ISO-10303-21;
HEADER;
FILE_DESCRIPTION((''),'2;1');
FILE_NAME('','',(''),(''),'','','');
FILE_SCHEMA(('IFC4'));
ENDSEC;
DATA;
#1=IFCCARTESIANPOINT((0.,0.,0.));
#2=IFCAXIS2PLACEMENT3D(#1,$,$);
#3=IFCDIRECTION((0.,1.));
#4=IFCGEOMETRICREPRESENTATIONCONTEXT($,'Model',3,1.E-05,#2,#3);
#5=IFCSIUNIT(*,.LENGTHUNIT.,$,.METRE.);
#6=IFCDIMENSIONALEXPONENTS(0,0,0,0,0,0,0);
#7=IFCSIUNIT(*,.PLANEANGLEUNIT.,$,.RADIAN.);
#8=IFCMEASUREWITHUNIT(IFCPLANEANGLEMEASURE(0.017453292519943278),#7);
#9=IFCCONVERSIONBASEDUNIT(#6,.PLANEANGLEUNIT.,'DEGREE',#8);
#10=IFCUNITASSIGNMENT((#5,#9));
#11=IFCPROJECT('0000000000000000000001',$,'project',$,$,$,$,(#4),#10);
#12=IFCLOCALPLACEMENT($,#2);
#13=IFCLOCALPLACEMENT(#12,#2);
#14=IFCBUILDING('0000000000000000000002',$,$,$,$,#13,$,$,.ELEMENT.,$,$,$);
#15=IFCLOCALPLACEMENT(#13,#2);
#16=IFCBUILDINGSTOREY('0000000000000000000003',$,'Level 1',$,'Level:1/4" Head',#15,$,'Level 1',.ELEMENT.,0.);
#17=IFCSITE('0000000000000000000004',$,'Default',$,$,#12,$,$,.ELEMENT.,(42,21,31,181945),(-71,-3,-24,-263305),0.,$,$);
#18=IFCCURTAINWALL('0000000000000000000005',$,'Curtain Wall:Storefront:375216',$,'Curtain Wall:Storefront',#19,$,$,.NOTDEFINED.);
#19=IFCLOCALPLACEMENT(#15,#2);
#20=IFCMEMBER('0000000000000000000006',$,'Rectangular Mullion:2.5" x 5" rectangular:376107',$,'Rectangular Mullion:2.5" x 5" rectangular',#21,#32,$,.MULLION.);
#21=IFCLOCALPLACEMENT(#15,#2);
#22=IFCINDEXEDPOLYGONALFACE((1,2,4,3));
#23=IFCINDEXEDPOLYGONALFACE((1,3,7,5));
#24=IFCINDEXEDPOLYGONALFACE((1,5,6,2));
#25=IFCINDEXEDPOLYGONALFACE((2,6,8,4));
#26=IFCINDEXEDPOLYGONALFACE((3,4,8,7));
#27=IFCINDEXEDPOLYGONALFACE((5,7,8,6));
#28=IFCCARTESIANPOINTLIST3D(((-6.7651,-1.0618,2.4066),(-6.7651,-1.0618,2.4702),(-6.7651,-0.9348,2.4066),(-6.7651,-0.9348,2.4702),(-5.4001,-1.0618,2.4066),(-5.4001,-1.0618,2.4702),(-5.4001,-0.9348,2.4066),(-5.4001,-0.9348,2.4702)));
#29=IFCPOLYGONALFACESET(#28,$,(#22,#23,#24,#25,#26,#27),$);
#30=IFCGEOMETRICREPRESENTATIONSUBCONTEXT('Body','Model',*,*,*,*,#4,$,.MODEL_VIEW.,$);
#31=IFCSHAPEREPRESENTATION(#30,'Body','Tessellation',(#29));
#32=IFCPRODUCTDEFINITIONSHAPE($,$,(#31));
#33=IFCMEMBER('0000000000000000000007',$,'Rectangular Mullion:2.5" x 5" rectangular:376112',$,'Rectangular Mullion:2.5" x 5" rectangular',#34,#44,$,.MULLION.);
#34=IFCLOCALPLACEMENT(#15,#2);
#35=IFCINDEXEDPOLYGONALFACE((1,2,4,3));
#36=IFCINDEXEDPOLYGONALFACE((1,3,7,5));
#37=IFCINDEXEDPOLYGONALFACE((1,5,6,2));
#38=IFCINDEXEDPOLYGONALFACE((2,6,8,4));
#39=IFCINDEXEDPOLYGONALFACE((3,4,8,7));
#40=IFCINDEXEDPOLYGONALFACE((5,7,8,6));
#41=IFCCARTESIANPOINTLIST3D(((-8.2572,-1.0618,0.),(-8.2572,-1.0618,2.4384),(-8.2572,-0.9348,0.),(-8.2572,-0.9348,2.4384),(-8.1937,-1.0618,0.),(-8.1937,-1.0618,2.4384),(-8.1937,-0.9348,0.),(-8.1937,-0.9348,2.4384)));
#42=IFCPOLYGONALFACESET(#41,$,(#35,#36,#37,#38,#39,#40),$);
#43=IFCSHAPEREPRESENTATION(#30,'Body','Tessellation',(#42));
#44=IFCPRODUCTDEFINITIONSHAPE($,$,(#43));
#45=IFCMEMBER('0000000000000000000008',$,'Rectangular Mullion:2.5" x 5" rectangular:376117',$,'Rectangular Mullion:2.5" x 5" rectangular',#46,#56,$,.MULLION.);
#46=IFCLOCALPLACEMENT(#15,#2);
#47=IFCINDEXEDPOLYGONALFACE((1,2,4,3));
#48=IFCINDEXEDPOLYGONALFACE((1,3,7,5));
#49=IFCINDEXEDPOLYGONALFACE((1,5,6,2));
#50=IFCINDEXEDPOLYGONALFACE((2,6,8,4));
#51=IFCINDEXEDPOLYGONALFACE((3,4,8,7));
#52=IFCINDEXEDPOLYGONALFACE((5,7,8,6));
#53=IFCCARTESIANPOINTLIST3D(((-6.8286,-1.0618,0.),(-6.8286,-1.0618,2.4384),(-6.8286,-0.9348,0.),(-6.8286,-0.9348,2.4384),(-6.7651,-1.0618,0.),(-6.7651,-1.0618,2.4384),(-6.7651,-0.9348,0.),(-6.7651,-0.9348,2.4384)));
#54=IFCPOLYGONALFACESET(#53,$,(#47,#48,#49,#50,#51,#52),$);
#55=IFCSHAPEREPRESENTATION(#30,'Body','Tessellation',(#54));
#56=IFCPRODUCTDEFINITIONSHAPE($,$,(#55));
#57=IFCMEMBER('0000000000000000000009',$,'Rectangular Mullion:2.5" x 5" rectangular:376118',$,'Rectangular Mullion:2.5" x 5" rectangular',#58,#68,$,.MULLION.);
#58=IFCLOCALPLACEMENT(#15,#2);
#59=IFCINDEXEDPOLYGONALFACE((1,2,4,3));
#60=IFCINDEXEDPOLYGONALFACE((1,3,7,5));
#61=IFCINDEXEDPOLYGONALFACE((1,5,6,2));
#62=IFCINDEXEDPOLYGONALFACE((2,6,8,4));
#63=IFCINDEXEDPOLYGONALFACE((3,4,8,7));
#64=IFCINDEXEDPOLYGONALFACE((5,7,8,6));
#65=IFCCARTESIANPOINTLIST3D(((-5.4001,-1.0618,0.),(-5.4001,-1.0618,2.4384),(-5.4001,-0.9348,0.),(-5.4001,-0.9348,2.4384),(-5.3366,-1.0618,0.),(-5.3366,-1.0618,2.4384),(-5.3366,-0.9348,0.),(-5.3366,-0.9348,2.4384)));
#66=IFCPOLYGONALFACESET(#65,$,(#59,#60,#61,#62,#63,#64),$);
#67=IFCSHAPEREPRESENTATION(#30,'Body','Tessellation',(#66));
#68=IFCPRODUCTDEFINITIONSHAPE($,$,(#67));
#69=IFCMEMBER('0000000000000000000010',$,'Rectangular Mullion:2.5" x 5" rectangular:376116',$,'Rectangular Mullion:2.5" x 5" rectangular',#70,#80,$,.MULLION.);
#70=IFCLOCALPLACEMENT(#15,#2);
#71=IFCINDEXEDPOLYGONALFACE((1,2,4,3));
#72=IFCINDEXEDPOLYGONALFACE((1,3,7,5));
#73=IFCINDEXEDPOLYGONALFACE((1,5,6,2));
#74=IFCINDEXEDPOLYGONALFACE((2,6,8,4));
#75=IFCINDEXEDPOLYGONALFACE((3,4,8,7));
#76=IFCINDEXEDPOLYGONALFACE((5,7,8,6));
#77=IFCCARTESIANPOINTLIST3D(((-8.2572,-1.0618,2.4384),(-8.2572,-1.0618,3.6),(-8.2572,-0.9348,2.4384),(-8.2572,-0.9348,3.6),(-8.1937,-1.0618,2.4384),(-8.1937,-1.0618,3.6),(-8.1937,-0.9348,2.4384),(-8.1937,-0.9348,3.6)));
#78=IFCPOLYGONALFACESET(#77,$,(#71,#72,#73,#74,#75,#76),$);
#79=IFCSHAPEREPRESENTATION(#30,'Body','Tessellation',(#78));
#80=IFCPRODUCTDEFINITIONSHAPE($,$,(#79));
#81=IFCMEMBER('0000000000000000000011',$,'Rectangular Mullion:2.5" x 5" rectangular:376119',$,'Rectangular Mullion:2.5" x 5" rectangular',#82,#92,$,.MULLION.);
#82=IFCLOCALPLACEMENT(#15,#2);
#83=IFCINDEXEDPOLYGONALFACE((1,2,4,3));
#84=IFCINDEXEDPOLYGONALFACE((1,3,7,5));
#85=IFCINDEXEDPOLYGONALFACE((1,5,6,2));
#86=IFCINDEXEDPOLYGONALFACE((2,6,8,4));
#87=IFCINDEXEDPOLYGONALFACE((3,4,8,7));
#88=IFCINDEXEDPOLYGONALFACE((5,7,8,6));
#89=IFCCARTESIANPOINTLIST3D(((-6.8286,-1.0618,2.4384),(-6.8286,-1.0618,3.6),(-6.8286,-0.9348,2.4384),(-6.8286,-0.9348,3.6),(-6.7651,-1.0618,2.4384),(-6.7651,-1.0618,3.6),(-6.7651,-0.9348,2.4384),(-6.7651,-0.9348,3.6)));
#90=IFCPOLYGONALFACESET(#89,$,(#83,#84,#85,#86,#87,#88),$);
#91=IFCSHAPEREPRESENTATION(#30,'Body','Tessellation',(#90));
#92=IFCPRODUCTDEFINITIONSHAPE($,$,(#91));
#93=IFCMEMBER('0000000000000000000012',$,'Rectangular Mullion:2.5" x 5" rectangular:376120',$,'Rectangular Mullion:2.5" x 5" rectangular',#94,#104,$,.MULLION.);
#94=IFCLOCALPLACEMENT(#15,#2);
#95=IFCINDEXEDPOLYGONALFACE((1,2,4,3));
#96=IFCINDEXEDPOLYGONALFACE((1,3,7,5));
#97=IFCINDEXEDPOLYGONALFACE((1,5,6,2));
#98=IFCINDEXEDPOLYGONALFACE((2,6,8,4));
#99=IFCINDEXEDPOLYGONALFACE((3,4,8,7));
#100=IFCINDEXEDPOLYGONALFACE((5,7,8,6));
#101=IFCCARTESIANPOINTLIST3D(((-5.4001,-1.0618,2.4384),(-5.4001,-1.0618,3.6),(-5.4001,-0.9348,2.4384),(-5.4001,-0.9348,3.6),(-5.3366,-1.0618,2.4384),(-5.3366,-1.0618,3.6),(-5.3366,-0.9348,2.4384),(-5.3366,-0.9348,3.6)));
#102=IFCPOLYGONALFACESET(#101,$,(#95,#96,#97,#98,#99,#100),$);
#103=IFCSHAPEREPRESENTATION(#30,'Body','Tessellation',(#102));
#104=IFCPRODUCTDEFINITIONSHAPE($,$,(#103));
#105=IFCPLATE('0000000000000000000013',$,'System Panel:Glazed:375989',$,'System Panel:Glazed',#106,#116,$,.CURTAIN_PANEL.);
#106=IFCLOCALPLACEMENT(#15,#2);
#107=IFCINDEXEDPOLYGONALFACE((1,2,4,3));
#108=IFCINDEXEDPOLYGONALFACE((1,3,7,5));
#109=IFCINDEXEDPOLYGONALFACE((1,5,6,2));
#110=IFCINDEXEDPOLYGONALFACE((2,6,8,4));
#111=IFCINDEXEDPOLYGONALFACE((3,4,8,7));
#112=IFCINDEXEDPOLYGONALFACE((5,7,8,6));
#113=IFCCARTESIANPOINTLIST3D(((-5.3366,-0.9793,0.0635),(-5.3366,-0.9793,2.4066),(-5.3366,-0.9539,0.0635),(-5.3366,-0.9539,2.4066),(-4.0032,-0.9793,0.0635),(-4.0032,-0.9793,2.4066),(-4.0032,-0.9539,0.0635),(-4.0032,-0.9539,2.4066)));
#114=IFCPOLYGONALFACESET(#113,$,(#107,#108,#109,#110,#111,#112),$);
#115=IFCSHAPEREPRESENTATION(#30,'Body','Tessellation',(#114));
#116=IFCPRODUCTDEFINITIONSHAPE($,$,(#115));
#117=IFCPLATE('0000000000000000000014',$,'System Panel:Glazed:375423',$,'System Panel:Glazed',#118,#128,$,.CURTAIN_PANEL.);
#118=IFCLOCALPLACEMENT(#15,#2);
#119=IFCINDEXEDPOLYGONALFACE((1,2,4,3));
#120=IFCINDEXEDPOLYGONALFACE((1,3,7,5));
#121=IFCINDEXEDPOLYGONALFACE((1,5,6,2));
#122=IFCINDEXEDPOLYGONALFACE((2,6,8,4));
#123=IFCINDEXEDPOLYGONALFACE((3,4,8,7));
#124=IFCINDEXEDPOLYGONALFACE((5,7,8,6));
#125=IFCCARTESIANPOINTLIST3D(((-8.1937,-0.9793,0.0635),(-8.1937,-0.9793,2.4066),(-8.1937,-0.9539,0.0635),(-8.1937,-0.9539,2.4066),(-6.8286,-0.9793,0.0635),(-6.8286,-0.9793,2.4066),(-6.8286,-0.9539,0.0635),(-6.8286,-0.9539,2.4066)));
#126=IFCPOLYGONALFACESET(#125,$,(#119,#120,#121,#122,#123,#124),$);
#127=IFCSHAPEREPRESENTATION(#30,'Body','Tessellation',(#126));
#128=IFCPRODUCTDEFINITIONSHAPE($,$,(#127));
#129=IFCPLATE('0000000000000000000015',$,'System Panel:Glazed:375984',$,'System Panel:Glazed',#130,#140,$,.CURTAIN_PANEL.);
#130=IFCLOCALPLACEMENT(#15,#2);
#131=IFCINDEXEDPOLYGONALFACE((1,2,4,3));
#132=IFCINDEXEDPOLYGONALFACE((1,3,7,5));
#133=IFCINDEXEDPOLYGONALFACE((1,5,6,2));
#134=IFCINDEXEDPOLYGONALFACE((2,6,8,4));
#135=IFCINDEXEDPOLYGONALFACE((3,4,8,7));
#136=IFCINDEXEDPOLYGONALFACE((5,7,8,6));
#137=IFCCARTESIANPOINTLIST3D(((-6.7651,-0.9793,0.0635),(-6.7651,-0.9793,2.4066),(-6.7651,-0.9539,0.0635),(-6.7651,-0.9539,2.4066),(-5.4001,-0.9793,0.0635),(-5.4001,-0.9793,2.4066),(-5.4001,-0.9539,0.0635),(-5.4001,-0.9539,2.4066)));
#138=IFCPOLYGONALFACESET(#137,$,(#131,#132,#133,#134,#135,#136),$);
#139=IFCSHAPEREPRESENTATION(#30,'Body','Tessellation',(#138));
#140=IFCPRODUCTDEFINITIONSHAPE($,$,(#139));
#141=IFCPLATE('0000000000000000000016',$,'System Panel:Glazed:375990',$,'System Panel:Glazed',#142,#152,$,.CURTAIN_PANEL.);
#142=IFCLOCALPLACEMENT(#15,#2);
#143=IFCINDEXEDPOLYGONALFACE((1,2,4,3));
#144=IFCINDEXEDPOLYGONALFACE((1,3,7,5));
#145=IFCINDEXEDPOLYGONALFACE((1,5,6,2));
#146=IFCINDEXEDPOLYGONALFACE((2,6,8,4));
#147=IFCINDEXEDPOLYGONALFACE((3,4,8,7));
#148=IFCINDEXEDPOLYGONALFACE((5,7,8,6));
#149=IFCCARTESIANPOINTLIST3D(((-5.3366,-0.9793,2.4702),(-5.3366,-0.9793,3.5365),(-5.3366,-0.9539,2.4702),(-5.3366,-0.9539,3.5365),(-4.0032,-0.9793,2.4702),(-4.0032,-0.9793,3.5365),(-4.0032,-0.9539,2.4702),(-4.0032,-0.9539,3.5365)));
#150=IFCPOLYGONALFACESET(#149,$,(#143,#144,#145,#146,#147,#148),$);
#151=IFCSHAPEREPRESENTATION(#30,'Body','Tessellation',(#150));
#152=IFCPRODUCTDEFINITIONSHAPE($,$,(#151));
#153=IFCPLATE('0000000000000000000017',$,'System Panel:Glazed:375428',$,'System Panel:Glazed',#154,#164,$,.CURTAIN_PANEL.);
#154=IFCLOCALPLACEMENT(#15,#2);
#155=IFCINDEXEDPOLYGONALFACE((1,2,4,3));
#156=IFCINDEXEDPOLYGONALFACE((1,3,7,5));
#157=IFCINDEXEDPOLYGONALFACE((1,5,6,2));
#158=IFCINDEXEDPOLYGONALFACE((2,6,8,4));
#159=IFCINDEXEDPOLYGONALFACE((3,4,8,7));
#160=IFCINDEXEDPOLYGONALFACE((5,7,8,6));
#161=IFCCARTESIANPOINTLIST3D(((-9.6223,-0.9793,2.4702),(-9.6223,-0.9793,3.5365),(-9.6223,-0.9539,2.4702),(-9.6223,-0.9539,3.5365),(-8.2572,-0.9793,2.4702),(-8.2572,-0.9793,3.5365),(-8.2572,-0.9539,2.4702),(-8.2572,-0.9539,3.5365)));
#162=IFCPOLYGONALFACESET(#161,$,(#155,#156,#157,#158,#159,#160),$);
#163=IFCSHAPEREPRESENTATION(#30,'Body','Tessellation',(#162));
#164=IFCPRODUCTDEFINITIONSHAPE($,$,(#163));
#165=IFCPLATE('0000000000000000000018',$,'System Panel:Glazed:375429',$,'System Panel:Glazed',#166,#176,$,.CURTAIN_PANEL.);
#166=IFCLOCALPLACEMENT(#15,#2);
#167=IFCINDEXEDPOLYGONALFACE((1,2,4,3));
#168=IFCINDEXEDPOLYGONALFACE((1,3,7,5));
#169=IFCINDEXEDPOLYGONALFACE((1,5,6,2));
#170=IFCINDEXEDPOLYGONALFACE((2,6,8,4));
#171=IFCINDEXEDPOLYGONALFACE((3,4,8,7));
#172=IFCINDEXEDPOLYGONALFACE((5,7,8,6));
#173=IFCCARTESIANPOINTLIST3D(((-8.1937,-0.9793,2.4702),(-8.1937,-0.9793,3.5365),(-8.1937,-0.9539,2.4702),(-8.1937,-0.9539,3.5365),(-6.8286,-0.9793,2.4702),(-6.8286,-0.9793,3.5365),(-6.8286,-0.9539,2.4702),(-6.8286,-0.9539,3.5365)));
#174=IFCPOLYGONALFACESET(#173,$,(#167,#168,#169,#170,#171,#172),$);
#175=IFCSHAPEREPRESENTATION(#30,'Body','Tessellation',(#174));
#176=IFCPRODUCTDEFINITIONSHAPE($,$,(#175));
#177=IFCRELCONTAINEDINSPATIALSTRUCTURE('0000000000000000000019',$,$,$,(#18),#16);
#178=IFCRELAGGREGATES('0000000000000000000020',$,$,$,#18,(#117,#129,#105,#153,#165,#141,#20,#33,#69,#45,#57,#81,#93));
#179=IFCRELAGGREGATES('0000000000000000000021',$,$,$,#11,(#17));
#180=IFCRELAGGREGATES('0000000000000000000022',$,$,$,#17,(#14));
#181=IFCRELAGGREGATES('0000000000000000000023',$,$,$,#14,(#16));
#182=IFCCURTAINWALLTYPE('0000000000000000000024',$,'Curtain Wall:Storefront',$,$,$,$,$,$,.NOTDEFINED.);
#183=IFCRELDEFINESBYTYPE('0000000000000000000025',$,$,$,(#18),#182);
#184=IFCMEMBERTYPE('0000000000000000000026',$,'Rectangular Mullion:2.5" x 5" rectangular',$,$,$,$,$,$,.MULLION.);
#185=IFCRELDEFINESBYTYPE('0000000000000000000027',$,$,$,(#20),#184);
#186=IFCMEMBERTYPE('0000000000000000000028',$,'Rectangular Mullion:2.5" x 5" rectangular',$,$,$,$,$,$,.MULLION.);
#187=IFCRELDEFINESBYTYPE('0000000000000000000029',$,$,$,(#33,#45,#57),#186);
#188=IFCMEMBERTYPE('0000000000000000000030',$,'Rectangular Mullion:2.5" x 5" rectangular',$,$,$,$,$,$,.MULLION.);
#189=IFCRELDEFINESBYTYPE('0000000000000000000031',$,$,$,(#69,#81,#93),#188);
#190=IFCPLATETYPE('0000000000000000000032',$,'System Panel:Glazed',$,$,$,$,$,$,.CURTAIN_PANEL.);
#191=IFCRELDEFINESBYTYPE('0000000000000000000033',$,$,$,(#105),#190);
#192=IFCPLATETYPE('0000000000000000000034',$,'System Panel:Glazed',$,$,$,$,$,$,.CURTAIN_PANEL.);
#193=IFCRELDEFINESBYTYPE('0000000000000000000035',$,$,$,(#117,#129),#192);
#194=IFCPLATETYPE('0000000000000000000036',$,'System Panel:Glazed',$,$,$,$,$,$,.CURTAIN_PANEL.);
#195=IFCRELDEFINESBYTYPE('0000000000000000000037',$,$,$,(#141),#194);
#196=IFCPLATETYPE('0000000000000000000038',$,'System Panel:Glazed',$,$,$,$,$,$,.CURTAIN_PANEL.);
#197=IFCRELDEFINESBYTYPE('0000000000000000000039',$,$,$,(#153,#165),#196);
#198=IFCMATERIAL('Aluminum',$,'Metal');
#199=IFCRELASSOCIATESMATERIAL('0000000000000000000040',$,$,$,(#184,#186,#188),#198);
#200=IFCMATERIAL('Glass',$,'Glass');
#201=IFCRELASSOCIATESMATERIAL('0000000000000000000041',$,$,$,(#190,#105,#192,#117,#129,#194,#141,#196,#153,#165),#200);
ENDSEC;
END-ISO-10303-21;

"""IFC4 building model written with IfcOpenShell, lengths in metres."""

from ifc_helpers import new_model, entity, si_unit, converted_unit, direction, frame, frame_2d, origin, origin_2d_with_axis, place, context, subcontext, project, spatial, rectangle, extrude, source, transform, mapped, material, material_profile, profile_set, type_object, type_shapes, element, aggregate, save


model = new_model("IFC4")

# Units and contexts
model_context = context("Model", 3, precision=1e-05, world=origin(), true_north=direction((0.0, 1.0)))
body_context = subcontext(model_context, "Body", "Model", "MODEL_VIEW")
ifc_project = project(units=[si_unit("LENGTHUNIT", "METRE"), converted_unit("PLANEANGLEUNIT", "DEGREE", entity("IfcPlaneAngleMeasure", 0.017453292519943278), si_unit("PLANEANGLEUNIT", "RADIAN"), dimensions=[0, 0, 0, 0, 0, 0, 0])], contexts=[model_context])

# Site, building, storey
site_placement = place(None, origin())
site = spatial("IfcSite", under=ifc_project, at=site_placement, Name="Default", CompositionType="ELEMENT", RefLatitude=(42, 21, 31, 181945), RefLongitude=(-71, -3, -24, -263305), RefElevation=0.0)
building_placement = place(site_placement, origin())
building = spatial("IfcBuilding", under=site, at=building_placement, CompositionType="ELEMENT")
storey_placement = place(building_placement, origin())
storey = spatial("IfcBuildingStorey", under=building, at=storey_placement, Name="Level 1", ObjectType="Level:1/4\" Head", LongName="Level 1", CompositionType="ELEMENT", Elevation=0.0)

# Curtain wall, members, plates
curtain_wall_type = type_object("IfcCurtainWallType", Name="Curtain Wall:Storefront", PredefinedType="NOTDEFINED")
curtain_wall_placement = place(storey_placement, origin())
curtain_wall = element("IfcCurtainWall", 1, at=curtain_wall_placement, inside=storey, type_object=curtain_wall_type, Name="Curtain Wall:Storefront:375216", ObjectType="Curtain Wall:Storefront", PredefinedType="NOTDEFINED")
ifc_material_1 = material(Name="Aluminum", Category="Metal")
ifc_material_profile = material_profile(ifc_material_1, rectangle(XDim=0.0635, YDim=0.127, at=frame_2d((0.0, 0.0), x_axis=(1.0, 0.0))), Name="2.5\" x 5\" rectangular")
ifc_profile_set = profile_set([ifc_material_profile], Name="2.5\" x 5\" rectangular")
member_type_1 = type_object("IfcMemberType", Name="Rectangular Mullion:2.5\" x 5\" rectangular", PredefinedType="MULLION", material=ifc_profile_set)
shared_shape_1 = source(origin(), body_context, "Body", "SweptSolid", [
    extrude(rectangle(XDim=0.0635, YDim=0.127, at=origin_2d_with_axis()), frame((0.0, 0.0, -1.3651), z_axis=(0.0, 0.0, 1.0), x_axis=(-1.0, 0.0, 0.0)), (0.0, 0.0, 1.0), 1.3651),
])
type_shapes(member_type_1, [shared_shape_1])
member_1_placement = place(curtain_wall_placement, frame((-5.4001, -0.9983, 2.4384), z_axis=(1.0, 0.0, 0.0), x_axis=(0.0, 0.0, 1.0)))
member_1 = element("IfcMember", 2, at=member_1_placement, type_object=member_type_1, Name="Rectangular Mullion:2.5\" x 5\" rectangular:376107", ObjectType="Rectangular Mullion:2.5\" x 5\" rectangular", PredefinedType="MULLION", context=body_context, shape_type="MappedRepresentation", body=[
    mapped(shared_shape_1, transform((0.0, 0.0, 0.0), scale=1.0)),
])
member_type_2 = type_object("IfcMemberType", Name="Rectangular Mullion:2.5\" x 5\" rectangular", PredefinedType="MULLION", material=ifc_profile_set)
shared_shape_2 = source(origin(), body_context, "Body", "SweptSolid", [
    extrude(rectangle(XDim=0.0635, YDim=0.127, at=origin_2d_with_axis()), frame((0.0, 0.0, -2.4384), z_axis=(0.0, 0.0, 1.0), x_axis=(-1.0, 0.0, 0.0)), (0.0, 0.0, 1.0), 2.4384),
])
type_shapes(member_type_2, [shared_shape_2])
member_2_placement = place(curtain_wall_placement, frame((-8.2254, -0.9983, 0.0), z_axis=(0.0, 0.0, -1.0), x_axis=(1.0, 0.0, 0.0)))
member_2 = element("IfcMember", 3, at=member_2_placement, type_object=member_type_2, Name="Rectangular Mullion:2.5\" x 5\" rectangular:376112", ObjectType="Rectangular Mullion:2.5\" x 5\" rectangular", PredefinedType="MULLION", context=body_context, shape_type="MappedRepresentation", body=[
    mapped(shared_shape_2, transform((0.0, 0.0, 0.0), scale=1.0)),
])
member_3_placement = place(curtain_wall_placement, frame((-6.7969, -0.9983, 0.0), z_axis=(0.0, 0.0, -1.0), x_axis=(1.0, 0.0, 0.0)))
member_3 = element("IfcMember", 4, at=member_3_placement, type_object=member_type_2, Name="Rectangular Mullion:2.5\" x 5\" rectangular:376117", ObjectType="Rectangular Mullion:2.5\" x 5\" rectangular", PredefinedType="MULLION", context=body_context, shape_type="MappedRepresentation", body=[
    mapped(shared_shape_2, transform((0.0, 0.0, 0.0), scale=1.0)),
])
member_4_placement = place(curtain_wall_placement, frame((-5.3683, -0.9983, 0.0), z_axis=(0.0, 0.0, -1.0), x_axis=(1.0, 0.0, 0.0)))
member_4 = element("IfcMember", 5, at=member_4_placement, type_object=member_type_2, Name="Rectangular Mullion:2.5\" x 5\" rectangular:376118", ObjectType="Rectangular Mullion:2.5\" x 5\" rectangular", PredefinedType="MULLION", context=body_context, shape_type="MappedRepresentation", body=[
    mapped(shared_shape_2, transform((0.0, 0.0, 0.0), scale=1.0)),
])
member_type_3 = type_object("IfcMemberType", Name="Rectangular Mullion:2.5\" x 5\" rectangular", PredefinedType="MULLION", material=ifc_profile_set)
shared_shape_3 = source(origin(), body_context, "Body", "SweptSolid", [
    extrude(rectangle(XDim=0.0635, YDim=0.127, at=origin_2d_with_axis()), frame((0.0, 0.0, -1.1616), z_axis=(0.0, 0.0, 1.0), x_axis=(-1.0, 0.0, 0.0)), (0.0, 0.0, 1.0), 1.1616),
])
type_shapes(member_type_3, [shared_shape_3])
member_5_placement = place(curtain_wall_placement, frame((-8.2254, -0.9983, 2.4384), z_axis=(0.0, 0.0, -1.0), x_axis=(1.0, 0.0, 0.0)))
member_5 = element("IfcMember", 6, at=member_5_placement, type_object=member_type_3, Name="Rectangular Mullion:2.5\" x 5\" rectangular:376116", ObjectType="Rectangular Mullion:2.5\" x 5\" rectangular", PredefinedType="MULLION", context=body_context, shape_type="MappedRepresentation", body=[
    mapped(shared_shape_3, transform((0.0, 0.0, 0.0), scale=1.0)),
])
member_6_placement = place(curtain_wall_placement, frame((-6.7969, -0.9983, 2.4384), z_axis=(0.0, 0.0, -1.0), x_axis=(1.0, 0.0, 0.0)))
member_6 = element("IfcMember", 7, at=member_6_placement, type_object=member_type_3, Name="Rectangular Mullion:2.5\" x 5\" rectangular:376119", ObjectType="Rectangular Mullion:2.5\" x 5\" rectangular", PredefinedType="MULLION", context=body_context, shape_type="MappedRepresentation", body=[
    mapped(shared_shape_3, transform((0.0, 0.0, 0.0), scale=1.0)),
])
member_7_placement = place(curtain_wall_placement, frame((-5.3683, -0.9983, 2.4384), z_axis=(0.0, 0.0, -1.0), x_axis=(1.0, 0.0, 0.0)))
member_7 = element("IfcMember", 8, at=member_7_placement, type_object=member_type_3, Name="Rectangular Mullion:2.5\" x 5\" rectangular:376120", ObjectType="Rectangular Mullion:2.5\" x 5\" rectangular", PredefinedType="MULLION", context=body_context, shape_type="MappedRepresentation", body=[
    mapped(shared_shape_3, transform((0.0, 0.0, 0.0), scale=1.0)),
])
ifc_material_2 = material(Name="Glass", Category="Glass")
plate_type_1 = type_object("IfcPlateType", Name="System Panel:Glazed", PredefinedType="CURTAIN_PANEL", material=ifc_material_2)
shared_shape_4 = source(origin(), body_context, "Body", "SweptSolid", [
    extrude(rectangle(XDim=0.0254, YDim=1.3333, at=frame_2d((0.0, 0.0), x_axis=(1.0, 0.0))), frame((0.6667, 0.0127, 0.0), z_axis=(0.0, 0.0, 1.0), x_axis=(0.0, 1.0, 0.0)), (0.0, 0.0, 1.0), 2.3432),
])
type_shapes(plate_type_1, [shared_shape_4])
plate_1_placement = place(curtain_wall_placement, frame((-5.3366, -0.9793, 0.0635)))
plate_1 = element("IfcPlate", 9, at=plate_1_placement, type_object=plate_type_1, material=ifc_material_2, Name="System Panel:Glazed:375989", ObjectType="System Panel:Glazed", PredefinedType="CURTAIN_PANEL", context=body_context, shape_type="MappedRepresentation", body=[
    mapped(shared_shape_4, transform((0.0, 0.0, 0.0), scale=1.0)),
])
plate_type_2 = type_object("IfcPlateType", Name="System Panel:Glazed", PredefinedType="CURTAIN_PANEL", material=ifc_material_2)
shared_shape_5 = source(origin(), body_context, "Body", "SweptSolid", [
    extrude(rectangle(XDim=0.0254, YDim=1.3651, at=frame_2d((0.0, 0.0), x_axis=(1.0, 0.0))), frame((0.6825, 0.0127, 0.0), z_axis=(0.0, 0.0, 1.0), x_axis=(0.0, 1.0, 0.0)), (0.0, 0.0, 1.0), 2.3432),
])
type_shapes(plate_type_2, [shared_shape_5])
plate_2_placement = place(curtain_wall_placement, frame((-8.1937, -0.9793, 0.0635)))
plate_2 = element("IfcPlate", 10, at=plate_2_placement, type_object=plate_type_2, material=ifc_material_2, Name="System Panel:Glazed:375423", ObjectType="System Panel:Glazed", PredefinedType="CURTAIN_PANEL", context=body_context, shape_type="MappedRepresentation", body=[
    mapped(shared_shape_5, transform((0.0, 0.0, 0.0), scale=1.0)),
])
plate_3_placement = place(curtain_wall_placement, frame((-6.7651, -0.9793, 0.0635)))
plate_3 = element("IfcPlate", 11, at=plate_3_placement, type_object=plate_type_2, material=ifc_material_2, Name="System Panel:Glazed:375984", ObjectType="System Panel:Glazed", PredefinedType="CURTAIN_PANEL", context=body_context, shape_type="MappedRepresentation", body=[
    mapped(shared_shape_5, transform((0.0, 0.0, 0.0), scale=1.0)),
])
plate_type_3 = type_object("IfcPlateType", Name="System Panel:Glazed", PredefinedType="CURTAIN_PANEL", material=ifc_material_2)
shared_shape_6 = source(origin(), body_context, "Body", "SweptSolid", [
    extrude(rectangle(XDim=0.0254, YDim=1.3333, at=frame_2d((0.0, 0.0), x_axis=(1.0, 0.0))), frame((0.6667, 0.0127, 0.0), z_axis=(0.0, 0.0, 1.0), x_axis=(0.0, 1.0, 0.0)), (0.0, 0.0, 1.0), 1.0663),
])
type_shapes(plate_type_3, [shared_shape_6])
plate_4_placement = place(curtain_wall_placement, frame((-5.3366, -0.9793, 2.4701)))
plate_4 = element("IfcPlate", 12, at=plate_4_placement, type_object=plate_type_3, material=ifc_material_2, Name="System Panel:Glazed:375990", ObjectType="System Panel:Glazed", PredefinedType="CURTAIN_PANEL", context=body_context, shape_type="MappedRepresentation", body=[
    mapped(shared_shape_6, transform((0.0, 0.0, 0.0), scale=1.0)),
])
plate_type_4 = type_object("IfcPlateType", Name="System Panel:Glazed", PredefinedType="CURTAIN_PANEL", material=ifc_material_2)
shared_shape_7 = source(origin(), body_context, "Body", "SweptSolid", [
    extrude(rectangle(XDim=0.0254, YDim=1.3651, at=frame_2d((0.0, 0.0), x_axis=(1.0, 0.0))), frame((0.6825, 0.0127, 0.0), z_axis=(0.0, 0.0, 1.0), x_axis=(0.0, 1.0, 0.0)), (0.0, 0.0, 1.0), 1.0663),
])
type_shapes(plate_type_4, [shared_shape_7])
plate_5_placement = place(curtain_wall_placement, frame((-9.6223, -0.9793, 2.4701)))
plate_5 = element("IfcPlate", 13, at=plate_5_placement, type_object=plate_type_4, material=ifc_material_2, Name="System Panel:Glazed:375428", ObjectType="System Panel:Glazed", PredefinedType="CURTAIN_PANEL", context=body_context, shape_type="MappedRepresentation", body=[
    mapped(shared_shape_7, transform((0.0, 0.0, 0.0), scale=1.0)),
])
plate_6_placement = place(curtain_wall_placement, frame((-8.1937, -0.9793, 2.4701)))
plate_6 = element("IfcPlate", 14, at=plate_6_placement, type_object=plate_type_4, material=ifc_material_2, Name="System Panel:Glazed:375429", ObjectType="System Panel:Glazed", PredefinedType="CURTAIN_PANEL", context=body_context, shape_type="MappedRepresentation", body=[
    mapped(shared_shape_7, transform((0.0, 0.0, 0.0), scale=1.0)),
])
aggregate(curtain_wall, [plate_2, plate_3, plate_1, plate_5, plate_6, plate_4, member_1, member_2, member_5, member_3, member_4, member_6, member_7])

save(model, "model.ifc")
